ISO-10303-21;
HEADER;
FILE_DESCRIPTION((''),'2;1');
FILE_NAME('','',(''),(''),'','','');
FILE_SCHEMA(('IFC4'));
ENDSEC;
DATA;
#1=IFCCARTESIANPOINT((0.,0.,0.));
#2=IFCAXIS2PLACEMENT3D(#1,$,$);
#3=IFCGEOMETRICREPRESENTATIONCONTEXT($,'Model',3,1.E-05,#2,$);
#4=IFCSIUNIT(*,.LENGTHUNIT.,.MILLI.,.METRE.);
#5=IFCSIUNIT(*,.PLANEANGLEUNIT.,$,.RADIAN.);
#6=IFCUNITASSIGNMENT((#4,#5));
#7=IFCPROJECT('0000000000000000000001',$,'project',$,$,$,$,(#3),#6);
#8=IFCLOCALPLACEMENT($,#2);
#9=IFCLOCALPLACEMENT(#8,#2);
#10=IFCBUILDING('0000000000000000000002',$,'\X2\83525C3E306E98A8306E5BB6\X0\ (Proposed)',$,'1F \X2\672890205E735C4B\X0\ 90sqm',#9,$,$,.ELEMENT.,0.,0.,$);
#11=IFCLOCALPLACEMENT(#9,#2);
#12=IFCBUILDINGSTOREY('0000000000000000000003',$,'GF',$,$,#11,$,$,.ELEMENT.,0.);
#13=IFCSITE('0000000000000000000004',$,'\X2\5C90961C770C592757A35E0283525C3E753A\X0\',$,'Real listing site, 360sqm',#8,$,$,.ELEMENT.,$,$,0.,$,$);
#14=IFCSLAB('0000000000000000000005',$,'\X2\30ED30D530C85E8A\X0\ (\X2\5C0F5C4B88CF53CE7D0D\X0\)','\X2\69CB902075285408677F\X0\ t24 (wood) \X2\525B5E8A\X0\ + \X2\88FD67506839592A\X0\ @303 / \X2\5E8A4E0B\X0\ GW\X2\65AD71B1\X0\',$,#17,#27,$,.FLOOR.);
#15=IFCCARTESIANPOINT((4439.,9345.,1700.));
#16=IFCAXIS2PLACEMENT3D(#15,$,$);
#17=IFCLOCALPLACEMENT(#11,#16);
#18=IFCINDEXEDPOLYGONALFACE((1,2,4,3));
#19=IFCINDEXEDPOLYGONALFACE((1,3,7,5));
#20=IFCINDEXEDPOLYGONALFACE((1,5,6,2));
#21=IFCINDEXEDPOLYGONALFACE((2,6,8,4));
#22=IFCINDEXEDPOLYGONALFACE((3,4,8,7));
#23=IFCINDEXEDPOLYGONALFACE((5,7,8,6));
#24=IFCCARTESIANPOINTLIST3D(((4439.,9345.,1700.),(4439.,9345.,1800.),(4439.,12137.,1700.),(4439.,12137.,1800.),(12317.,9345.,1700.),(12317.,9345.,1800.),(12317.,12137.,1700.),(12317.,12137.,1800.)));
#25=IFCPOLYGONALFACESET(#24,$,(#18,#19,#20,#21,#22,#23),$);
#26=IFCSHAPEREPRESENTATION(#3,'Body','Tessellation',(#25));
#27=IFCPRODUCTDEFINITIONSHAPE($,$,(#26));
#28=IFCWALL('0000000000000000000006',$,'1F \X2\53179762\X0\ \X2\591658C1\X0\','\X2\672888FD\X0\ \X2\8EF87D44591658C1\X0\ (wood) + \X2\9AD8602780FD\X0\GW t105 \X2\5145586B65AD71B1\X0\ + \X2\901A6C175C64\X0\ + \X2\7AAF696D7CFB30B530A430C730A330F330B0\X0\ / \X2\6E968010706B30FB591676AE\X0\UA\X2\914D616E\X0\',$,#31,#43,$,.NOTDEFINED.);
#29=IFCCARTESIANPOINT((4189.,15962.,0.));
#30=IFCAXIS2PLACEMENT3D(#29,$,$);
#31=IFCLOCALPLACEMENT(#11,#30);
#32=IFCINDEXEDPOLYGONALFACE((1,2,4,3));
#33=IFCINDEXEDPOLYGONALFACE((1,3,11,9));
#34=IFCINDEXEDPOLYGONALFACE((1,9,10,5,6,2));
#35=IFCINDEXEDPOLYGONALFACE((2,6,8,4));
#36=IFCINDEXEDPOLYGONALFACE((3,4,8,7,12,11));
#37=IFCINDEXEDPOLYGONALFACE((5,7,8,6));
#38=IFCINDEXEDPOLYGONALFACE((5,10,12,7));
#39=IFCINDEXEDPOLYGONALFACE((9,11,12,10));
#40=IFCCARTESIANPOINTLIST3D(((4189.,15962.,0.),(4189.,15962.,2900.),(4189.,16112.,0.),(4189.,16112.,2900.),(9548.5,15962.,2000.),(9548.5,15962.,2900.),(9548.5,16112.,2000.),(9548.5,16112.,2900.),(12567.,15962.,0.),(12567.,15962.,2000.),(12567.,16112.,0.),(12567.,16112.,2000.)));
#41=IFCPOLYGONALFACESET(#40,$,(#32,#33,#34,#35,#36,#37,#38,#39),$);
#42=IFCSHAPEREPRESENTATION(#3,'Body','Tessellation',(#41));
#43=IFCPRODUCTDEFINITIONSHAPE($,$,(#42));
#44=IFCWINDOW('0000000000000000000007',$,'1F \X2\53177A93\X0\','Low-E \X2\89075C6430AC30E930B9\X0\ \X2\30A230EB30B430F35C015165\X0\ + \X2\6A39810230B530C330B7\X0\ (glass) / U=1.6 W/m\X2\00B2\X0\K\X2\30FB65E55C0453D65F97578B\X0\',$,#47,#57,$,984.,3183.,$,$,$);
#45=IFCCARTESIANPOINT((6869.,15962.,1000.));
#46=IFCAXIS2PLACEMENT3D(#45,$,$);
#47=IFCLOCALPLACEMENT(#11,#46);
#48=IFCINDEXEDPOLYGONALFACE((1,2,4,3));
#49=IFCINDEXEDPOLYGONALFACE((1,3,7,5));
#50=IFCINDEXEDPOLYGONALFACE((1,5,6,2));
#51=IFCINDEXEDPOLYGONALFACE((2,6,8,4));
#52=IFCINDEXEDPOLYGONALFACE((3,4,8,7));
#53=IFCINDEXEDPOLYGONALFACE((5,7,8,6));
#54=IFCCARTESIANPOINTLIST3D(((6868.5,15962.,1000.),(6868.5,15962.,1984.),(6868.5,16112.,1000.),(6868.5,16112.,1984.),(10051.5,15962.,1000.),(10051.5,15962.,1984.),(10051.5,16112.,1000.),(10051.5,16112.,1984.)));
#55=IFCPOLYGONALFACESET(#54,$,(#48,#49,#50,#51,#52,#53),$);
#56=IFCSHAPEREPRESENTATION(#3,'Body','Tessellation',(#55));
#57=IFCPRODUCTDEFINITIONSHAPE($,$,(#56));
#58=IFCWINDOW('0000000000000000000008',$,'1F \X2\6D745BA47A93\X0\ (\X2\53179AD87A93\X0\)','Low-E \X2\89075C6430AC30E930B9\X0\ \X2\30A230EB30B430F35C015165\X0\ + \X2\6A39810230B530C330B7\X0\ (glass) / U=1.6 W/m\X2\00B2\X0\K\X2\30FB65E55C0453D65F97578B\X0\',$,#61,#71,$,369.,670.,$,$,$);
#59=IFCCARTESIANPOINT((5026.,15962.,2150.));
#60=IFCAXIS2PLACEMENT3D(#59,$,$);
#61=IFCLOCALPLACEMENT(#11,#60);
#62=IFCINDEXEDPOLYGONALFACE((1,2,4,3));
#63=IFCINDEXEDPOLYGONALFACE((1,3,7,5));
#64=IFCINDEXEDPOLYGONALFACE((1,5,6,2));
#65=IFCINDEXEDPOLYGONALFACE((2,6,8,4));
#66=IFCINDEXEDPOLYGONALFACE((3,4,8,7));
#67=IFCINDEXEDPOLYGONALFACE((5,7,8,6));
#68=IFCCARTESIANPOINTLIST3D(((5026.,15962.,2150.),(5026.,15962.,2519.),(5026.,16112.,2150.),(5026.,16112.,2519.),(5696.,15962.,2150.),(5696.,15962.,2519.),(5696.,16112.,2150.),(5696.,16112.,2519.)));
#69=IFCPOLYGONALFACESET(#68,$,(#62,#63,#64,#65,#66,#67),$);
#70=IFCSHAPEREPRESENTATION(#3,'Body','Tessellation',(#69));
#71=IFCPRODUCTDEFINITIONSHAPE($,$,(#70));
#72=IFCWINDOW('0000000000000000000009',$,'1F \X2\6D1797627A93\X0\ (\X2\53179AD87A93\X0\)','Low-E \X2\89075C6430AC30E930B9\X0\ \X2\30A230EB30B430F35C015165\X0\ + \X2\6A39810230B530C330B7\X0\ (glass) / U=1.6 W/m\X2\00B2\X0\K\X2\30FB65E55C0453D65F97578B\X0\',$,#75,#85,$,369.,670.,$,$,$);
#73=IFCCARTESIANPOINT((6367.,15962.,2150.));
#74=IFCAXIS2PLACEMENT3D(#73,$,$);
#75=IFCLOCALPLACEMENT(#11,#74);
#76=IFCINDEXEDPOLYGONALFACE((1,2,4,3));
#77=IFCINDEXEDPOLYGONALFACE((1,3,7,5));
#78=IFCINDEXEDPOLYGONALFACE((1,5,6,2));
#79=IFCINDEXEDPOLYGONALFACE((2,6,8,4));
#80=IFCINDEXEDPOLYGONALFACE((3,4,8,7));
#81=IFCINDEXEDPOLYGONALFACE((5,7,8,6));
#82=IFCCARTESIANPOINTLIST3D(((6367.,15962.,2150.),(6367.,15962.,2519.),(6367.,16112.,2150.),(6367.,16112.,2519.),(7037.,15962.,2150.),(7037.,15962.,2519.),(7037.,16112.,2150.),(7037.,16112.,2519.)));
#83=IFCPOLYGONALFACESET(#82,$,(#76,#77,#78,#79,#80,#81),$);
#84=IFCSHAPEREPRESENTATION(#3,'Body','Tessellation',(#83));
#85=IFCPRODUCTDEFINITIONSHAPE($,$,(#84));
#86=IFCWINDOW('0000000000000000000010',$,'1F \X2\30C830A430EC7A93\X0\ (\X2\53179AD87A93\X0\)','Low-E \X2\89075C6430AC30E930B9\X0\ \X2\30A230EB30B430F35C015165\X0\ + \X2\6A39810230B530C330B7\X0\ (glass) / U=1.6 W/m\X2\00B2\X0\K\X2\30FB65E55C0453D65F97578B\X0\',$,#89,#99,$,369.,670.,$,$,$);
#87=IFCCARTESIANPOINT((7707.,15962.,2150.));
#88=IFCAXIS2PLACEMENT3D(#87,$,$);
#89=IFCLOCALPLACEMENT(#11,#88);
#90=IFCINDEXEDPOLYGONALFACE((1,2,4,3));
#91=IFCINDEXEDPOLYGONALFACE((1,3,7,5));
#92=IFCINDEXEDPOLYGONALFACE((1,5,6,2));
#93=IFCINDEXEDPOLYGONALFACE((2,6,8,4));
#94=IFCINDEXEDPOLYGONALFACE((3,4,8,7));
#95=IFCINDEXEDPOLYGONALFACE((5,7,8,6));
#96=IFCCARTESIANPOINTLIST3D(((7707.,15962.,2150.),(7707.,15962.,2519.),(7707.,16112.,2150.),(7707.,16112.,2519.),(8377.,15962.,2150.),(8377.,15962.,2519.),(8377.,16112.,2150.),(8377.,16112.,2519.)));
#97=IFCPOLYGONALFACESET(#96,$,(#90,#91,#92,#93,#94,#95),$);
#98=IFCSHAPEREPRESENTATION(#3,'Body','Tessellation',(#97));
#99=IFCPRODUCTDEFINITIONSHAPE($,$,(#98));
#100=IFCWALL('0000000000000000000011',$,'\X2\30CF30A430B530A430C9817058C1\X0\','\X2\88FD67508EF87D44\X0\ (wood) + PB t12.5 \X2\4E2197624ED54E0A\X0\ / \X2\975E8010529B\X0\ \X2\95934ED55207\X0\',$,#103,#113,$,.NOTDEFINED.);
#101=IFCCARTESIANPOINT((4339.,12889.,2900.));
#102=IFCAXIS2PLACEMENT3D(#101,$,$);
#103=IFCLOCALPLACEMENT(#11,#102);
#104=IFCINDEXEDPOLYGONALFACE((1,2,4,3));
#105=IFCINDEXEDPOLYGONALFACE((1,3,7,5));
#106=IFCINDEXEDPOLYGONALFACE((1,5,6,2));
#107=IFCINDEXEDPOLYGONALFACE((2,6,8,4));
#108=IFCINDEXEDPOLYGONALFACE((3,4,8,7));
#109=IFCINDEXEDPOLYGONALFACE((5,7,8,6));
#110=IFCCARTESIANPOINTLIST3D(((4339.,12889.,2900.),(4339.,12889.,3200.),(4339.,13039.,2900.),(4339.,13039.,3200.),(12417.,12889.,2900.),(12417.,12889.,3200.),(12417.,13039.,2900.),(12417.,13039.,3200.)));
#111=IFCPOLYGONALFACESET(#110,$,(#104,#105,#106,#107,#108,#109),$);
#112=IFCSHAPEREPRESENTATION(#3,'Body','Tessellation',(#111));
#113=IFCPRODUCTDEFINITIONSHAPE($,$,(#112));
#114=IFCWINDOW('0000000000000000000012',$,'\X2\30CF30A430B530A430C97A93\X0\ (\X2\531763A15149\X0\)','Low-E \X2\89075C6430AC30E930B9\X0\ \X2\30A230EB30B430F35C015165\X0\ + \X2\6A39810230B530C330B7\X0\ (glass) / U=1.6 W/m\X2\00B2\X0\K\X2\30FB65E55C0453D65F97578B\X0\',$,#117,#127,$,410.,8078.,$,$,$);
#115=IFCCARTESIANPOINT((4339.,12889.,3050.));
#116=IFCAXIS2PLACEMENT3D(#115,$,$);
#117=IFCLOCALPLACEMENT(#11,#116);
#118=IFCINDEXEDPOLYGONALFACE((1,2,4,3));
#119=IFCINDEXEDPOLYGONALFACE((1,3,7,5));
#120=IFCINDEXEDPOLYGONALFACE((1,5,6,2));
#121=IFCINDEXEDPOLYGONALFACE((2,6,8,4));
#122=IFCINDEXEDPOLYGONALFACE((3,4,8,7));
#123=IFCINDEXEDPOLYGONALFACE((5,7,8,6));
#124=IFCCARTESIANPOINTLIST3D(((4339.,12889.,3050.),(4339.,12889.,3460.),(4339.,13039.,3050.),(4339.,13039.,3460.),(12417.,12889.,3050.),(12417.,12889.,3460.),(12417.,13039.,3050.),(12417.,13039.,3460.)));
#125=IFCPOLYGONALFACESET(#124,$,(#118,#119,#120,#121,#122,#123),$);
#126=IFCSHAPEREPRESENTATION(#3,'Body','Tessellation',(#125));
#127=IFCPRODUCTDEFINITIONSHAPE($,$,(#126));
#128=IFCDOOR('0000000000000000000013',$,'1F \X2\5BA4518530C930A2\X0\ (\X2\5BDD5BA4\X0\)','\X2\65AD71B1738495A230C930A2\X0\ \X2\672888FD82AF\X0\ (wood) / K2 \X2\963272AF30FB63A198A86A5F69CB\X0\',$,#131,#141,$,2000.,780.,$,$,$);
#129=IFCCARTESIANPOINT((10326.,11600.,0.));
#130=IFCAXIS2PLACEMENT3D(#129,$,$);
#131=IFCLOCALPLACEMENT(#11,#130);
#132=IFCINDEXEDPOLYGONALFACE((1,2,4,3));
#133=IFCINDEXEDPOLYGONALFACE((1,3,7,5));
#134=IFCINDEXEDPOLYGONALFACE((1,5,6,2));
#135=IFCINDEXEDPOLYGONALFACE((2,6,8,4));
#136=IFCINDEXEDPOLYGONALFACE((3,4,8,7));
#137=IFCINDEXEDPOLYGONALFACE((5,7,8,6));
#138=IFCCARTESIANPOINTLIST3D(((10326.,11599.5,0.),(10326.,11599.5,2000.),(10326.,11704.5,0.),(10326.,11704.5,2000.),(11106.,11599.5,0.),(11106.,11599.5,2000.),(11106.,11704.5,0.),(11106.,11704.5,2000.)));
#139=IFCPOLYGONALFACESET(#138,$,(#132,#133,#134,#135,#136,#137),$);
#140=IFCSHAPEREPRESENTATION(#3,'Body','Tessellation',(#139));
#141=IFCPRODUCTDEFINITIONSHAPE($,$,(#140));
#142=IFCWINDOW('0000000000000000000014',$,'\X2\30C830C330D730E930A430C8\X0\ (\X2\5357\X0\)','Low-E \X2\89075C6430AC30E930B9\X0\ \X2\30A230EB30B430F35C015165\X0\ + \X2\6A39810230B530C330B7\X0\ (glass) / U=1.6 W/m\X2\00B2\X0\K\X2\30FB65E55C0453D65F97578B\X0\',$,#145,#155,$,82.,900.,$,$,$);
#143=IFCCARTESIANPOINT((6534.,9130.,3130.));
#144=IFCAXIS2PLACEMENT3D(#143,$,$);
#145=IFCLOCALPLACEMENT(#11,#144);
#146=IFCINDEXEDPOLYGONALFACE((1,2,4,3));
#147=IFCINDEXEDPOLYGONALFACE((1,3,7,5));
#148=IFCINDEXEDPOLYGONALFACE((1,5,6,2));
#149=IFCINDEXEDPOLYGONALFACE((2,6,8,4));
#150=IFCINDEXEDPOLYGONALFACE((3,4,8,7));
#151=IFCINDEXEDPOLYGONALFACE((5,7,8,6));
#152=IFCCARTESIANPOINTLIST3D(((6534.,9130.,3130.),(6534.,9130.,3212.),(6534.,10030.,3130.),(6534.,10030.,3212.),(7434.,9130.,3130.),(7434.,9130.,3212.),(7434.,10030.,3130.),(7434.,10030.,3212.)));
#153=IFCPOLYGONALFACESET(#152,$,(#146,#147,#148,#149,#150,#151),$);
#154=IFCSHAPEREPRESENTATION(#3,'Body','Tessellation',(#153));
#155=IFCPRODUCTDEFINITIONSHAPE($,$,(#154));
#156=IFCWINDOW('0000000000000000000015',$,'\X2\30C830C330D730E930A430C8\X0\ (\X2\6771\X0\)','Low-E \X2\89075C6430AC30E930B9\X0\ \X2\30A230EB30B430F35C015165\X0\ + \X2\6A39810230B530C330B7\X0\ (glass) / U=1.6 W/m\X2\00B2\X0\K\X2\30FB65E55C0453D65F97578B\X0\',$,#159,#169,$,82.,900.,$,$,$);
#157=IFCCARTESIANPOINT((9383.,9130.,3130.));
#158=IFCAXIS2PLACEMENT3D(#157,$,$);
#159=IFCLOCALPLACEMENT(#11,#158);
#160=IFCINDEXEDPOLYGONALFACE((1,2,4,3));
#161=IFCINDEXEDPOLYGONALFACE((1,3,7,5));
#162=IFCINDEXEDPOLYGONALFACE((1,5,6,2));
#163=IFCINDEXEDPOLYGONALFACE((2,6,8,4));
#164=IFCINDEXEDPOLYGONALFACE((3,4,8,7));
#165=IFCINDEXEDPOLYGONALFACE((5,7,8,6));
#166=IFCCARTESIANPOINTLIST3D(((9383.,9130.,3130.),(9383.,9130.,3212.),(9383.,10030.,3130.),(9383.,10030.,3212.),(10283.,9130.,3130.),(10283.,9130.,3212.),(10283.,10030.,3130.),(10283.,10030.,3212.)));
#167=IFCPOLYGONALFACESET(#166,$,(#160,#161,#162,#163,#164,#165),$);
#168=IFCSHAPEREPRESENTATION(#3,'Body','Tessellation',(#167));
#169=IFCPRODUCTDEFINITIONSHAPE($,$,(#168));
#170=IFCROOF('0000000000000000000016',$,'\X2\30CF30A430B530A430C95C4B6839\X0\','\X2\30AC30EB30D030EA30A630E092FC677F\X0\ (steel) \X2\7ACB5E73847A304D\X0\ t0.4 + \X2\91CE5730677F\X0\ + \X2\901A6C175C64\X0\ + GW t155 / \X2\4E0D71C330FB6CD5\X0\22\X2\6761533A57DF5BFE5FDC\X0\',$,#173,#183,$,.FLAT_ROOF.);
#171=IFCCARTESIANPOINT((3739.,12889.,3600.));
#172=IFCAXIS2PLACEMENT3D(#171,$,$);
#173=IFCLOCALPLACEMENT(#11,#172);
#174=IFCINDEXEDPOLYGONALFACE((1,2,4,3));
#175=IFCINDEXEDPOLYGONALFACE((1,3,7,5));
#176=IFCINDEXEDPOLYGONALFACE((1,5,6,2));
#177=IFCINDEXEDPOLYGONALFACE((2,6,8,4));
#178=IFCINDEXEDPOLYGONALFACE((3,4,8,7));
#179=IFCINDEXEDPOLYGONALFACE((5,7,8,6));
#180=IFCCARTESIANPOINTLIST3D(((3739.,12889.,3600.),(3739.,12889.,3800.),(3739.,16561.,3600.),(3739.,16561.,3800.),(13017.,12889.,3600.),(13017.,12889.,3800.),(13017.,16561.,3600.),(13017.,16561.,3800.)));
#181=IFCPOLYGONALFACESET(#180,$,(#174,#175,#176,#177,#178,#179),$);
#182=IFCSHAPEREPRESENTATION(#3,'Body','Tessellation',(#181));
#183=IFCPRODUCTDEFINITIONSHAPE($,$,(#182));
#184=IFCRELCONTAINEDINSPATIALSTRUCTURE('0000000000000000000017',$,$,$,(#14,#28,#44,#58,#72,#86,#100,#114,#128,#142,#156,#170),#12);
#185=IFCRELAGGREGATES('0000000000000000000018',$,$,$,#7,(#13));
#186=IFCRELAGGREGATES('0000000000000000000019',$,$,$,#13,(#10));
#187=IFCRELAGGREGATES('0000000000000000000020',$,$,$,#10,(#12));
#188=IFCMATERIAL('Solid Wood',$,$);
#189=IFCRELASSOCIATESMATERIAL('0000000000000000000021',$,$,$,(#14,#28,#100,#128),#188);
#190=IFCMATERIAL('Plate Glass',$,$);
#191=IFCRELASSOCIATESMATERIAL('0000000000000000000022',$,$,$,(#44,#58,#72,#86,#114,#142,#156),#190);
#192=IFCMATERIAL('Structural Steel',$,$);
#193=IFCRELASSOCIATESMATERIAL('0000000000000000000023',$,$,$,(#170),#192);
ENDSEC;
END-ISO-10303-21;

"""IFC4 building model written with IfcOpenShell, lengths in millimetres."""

from ifc_helpers import new_model, si_unit, frame, frame_2d, origin, place, context, project, spatial, rectangle, extrude, material, element, fill, save


model = new_model("IFC4")

# Units and contexts
model_context = context("Model", 3, precision=1e-05, world=origin())
ifc_project = project(units=[si_unit("LENGTHUNIT", "METRE", prefix="MILLI"), si_unit("PLANEANGLEUNIT", "RADIAN")], contexts=[model_context])

# Site, building, storey
site_placement = place(None, origin())
site = spatial("IfcSite", under=ifc_project, at=site_placement, Name="岐阜県大垣市荒尾町", ObjectType="Real listing site, 360sqm", CompositionType="ELEMENT", RefElevation=0.0)
building_placement = place(site_placement, origin())
building = spatial("IfcBuilding", under=site, at=building_placement, Name="荒尾の風の家 (Proposed)", ObjectType="1F 木造平屋 90sqm", CompositionType="ELEMENT", ElevationOfRefHeight=0.0, ElevationOfTerrain=0.0)
storey_placement = place(building_placement, origin())
storey = spatial("IfcBuildingStorey", under=building, at=storey_placement, Name="GF", CompositionType="ELEMENT", Elevation=0.0)

# Slab
ifc_material_1 = material(Name="Solid Wood")
slab_placement = place(storey_placement, frame((4439.0, 9345.0, 1700.0)))
element("IfcSlab", 1, at=slab_placement, inside=storey, material=ifc_material_1, Name="ロフト床 (小屋裏収納)", Description="構造用合板 t24 (wood) 剛床 + 製材根太 @303 / 床下 GW断熱", PredefinedType="FLOOR", context=model_context, shape_type="SweptSolid", body=[
    extrude(rectangle(XDim=7878.0, YDim=2792.0, at=frame_2d((3939.0, 1396.0))), frame((4439.0, 9345.0, 1700.0)), (0.0, 0.0, 1.0), 100.0),
])

# Wall, openings, windows
wall_1_placement = place(storey_placement, frame((4189.0, 15962.0, 0.0)))
wall_1 = element("IfcWall", 2, at=wall_1_placement, inside=storey, material=ifc_material_1, Name="1F 北面 外壁", Description="木製 軸組外壁 (wood) + 高性能GW t105 充填断熱 + 通気層 + 窯業系サイディング / 準耐火・外皮UA配慮", PredefinedType="NOTDEFINED", context=model_context, shape_type="SweptSolid", body=[
    extrude(rectangle(XDim=8378.0, YDim=150.0, at=frame_2d((4189.0, 75.0))), frame((4189.0, 15962.0, 0.0)), (0.0, 0.0, 1.0), 2900.0),
])
opening_1_placement = place(storey_placement, frame((6869.0, 15962.0, 1000.0)))
opening_1 = element("IfcOpeningElement", 3, at=opening_1_placement, cuts=wall_1, PredefinedType="NOTDEFINED", context=model_context, shape_type="SweptSolid", body=[
    extrude(rectangle(XDim=3183.0, YDim=150.0, at=frame_2d((1591.0, 75.0))), frame((6869.0, 15962.0, 1000.0)), (0.0, 0.0, 1.0), 984.0),
])
opening_2_placement = place(storey_placement, frame((5026.0, 15962.0, 2150.0)))
opening_2 = element("IfcOpeningElement", 4, at=opening_2_placement, cuts=wall_1, PredefinedType="NOTDEFINED", context=model_context, shape_type="SweptSolid", body=[
    extrude(rectangle(XDim=670.0, YDim=150.0, at=frame_2d((335.0, 75.0))), frame((5026.0, 15962.0, 2150.0)), (0.0, 0.0, 1.0), 369.0),
])
opening_3_placement = place(storey_placement, frame((6367.0, 15962.0, 2150.0)))
opening_3 = element("IfcOpeningElement", 5, at=opening_3_placement, cuts=wall_1, PredefinedType="NOTDEFINED", context=model_context, shape_type="SweptSolid", body=[
    extrude(rectangle(XDim=670.0, YDim=150.0, at=frame_2d((335.0, 75.0))), frame((6367.0, 15962.0, 2150.0)), (0.0, 0.0, 1.0), 369.0),
])
opening_4_placement = place(storey_placement, frame((7707.0, 15962.0, 2150.0)))
opening_4 = element("IfcOpeningElement", 6, at=opening_4_placement, cuts=wall_1, PredefinedType="NOTDEFINED", context=model_context, shape_type="SweptSolid", body=[
    extrude(rectangle(XDim=670.0, YDim=150.0, at=frame_2d((335.0, 75.0))), frame((7707.0, 15962.0, 2150.0)), (0.0, 0.0, 1.0), 369.0),
])
ifc_material_2 = material(Name="Plate Glass")
window_1_placement = place(storey_placement, frame((6869.0, 15962.0, 1000.0)))
window_1 = element("IfcWindow", 7, at=window_1_placement, inside=storey, material=ifc_material_2, Name="1F 北窓", Description="Low-E 複層ガラス アルゴン封入 + 樹脂サッシ (glass) / U=1.6 W/m²K・日射取得型", OverallHeight=984.0, OverallWidth=3183.0, context=model_context, shape_type="SweptSolid", body=[
    extrude(rectangle(XDim=3183.0, YDim=150.0, at=frame_2d((1591.0, 75.0))), frame((6869.0, 15962.0, 1000.0)), (0.0, 0.0, 1.0), 984.0),
])
fill(opening_1, window_1)
window_2_placement = place(storey_placement, frame((5026.0, 15962.0, 2150.0)))
window_2 = element("IfcWindow", 8, at=window_2_placement, inside=storey, material=ifc_material_2, Name="1F 浴室窓 (北高窓)", Description="Low-E 複層ガラス アルゴン封入 + 樹脂サッシ (glass) / U=1.6 W/m²K・日射取得型", OverallHeight=369.0, OverallWidth=670.0, context=model_context, shape_type="SweptSolid", body=[
    extrude(rectangle(XDim=670.0, YDim=150.0, at=frame_2d((335.0, 75.0))), frame((5026.0, 15962.0, 2150.0)), (0.0, 0.0, 1.0), 369.0),
])
fill(opening_2, window_2)
window_3_placement = place(storey_placement, frame((6367.0, 15962.0, 2150.0)))
window_3 = element("IfcWindow", 9, at=window_3_placement, inside=storey, material=ifc_material_2, Name="1F 洗面窓 (北高窓)", Description="Low-E 複層ガラス アルゴン封入 + 樹脂サッシ (glass) / U=1.6 W/m²K・日射取得型", OverallHeight=369.0, OverallWidth=670.0, context=model_context, shape_type="SweptSolid", body=[
    extrude(rectangle(XDim=670.0, YDim=150.0, at=frame_2d((335.0, 75.0))), frame((6367.0, 15962.0, 2150.0)), (0.0, 0.0, 1.0), 369.0),
])
fill(opening_3, window_3)
window_4_placement = place(storey_placement, frame((7707.0, 15962.0, 2150.0)))
window_4 = element("IfcWindow", 10, at=window_4_placement, inside=storey, material=ifc_material_2, Name="1F トイレ窓 (北高窓)", Description="Low-E 複層ガラス アルゴン封入 + 樹脂サッシ (glass) / U=1.6 W/m²K・日射取得型", OverallHeight=369.0, OverallWidth=670.0, context=model_context, shape_type="SweptSolid", body=[
    extrude(rectangle(XDim=670.0, YDim=150.0, at=frame_2d((335.0, 75.0))), frame((7707.0, 15962.0, 2150.0)), (0.0, 0.0, 1.0), 369.0),
])
fill(opening_4, window_4)

# Wall, opening, window
wall_2_placement = place(storey_placement, frame((4339.0, 12889.0, 2900.0)))
wall_2 = element("IfcWall", 11, at=wall_2_placement, inside=storey, material=ifc_material_1, Name="ハイサイド腰壁", Description="製材軸組 (wood) + PB t12.5 両面仕上 / 非耐力 間仕切", PredefinedType="NOTDEFINED", context=model_context, shape_type="SweptSolid", body=[
    extrude(rectangle(XDim=8078.0, YDim=150.0, at=frame_2d((4039.0, 75.0))), frame((4339.0, 12889.0, 2900.0)), (0.0, 0.0, 1.0), 700.0),
])
opening_5_placement = place(storey_placement, frame((4339.0, 12889.0, 3050.0)))
opening_5 = element("IfcOpeningElement", 12, at=opening_5_placement, cuts=wall_2, PredefinedType="NOTDEFINED", context=model_context, shape_type="SweptSolid", body=[
    extrude(rectangle(XDim=8078.0, YDim=150.0, at=frame_2d((4039.0, 75.0))), frame((4339.0, 12889.0, 3050.0)), (0.0, 0.0, 1.0), 410.0),
])
window_5_placement = place(storey_placement, frame((4339.0, 12889.0, 3050.0)))
window_5 = element("IfcWindow", 13, at=window_5_placement, inside=storey, material=ifc_material_2, Name="ハイサイド窓 (北採光)", Description="Low-E 複層ガラス アルゴン封入 + 樹脂サッシ (glass) / U=1.6 W/m²K・日射取得型", OverallHeight=410.0, OverallWidth=8078.0, context=model_context, shape_type="SweptSolid", body=[
    extrude(rectangle(XDim=8078.0, YDim=150.0, at=frame_2d((4039.0, 75.0))), frame((4339.0, 12889.0, 3050.0)), (0.0, 0.0, 1.0), 410.0),
])
fill(opening_5, window_5)

# Door
door_1_placement = place(storey_placement, frame((10326.0, 11600.0, 0.0)))
element("IfcDoor", 14, at=door_1_placement, inside=storey, material=ifc_material_1, Name="1F 室内ドア (寝室)", Description="断熱玄関ドア 木製芯 (wood) / K2 防犯・採風機構", OverallHeight=2000.0, OverallWidth=780.0, context=model_context, shape_type="SweptSolid", body=[
    extrude(rectangle(XDim=780.0, YDim=105.0, at=frame_2d((390.0, 52.0))), frame((10326.0, 11600.0, 0.0)), (0.0, 0.0, 1.0), 2000.0),
])

# Windows
window_6_placement = place(storey_placement, frame((6534.0, 9130.0, 3130.0)))
element("IfcWindow", 15, at=window_6_placement, inside=storey, material=ifc_material_2, Name="トップライト (南)", Description="Low-E 複層ガラス アルゴン封入 + 樹脂サッシ (glass) / U=1.6 W/m²K・日射取得型", OverallHeight=82.0, OverallWidth=900.0, context=model_context, shape_type="SweptSolid", body=[
    extrude(rectangle(XDim=900.0, YDim=900.0, at=frame_2d((450.0, 450.0))), frame((6534.0, 9130.0, 3130.0)), (0.0, 0.0, 1.0), 82.0),
])
window_7_placement = place(storey_placement, frame((9383.0, 9130.0, 3130.0)))
element("IfcWindow", 16, at=window_7_placement, inside=storey, material=ifc_material_2, Name="トップライト (東)", Description="Low-E 複層ガラス アルゴン封入 + 樹脂サッシ (glass) / U=1.6 W/m²K・日射取得型", OverallHeight=82.0, OverallWidth=900.0, context=model_context, shape_type="SweptSolid", body=[
    extrude(rectangle(XDim=900.0, YDim=900.0, at=frame_2d((450.0, 450.0))), frame((9383.0, 9130.0, 3130.0)), (0.0, 0.0, 1.0), 82.0),
])

# Roof
ifc_material_3 = material(Name="Structural Steel")
roof_placement = place(storey_placement, frame((3739.0, 12889.0, 3600.0)))
element("IfcRoof", 17, at=roof_placement, inside=storey, material=ifc_material_3, Name="ハイサイド屋根", Description="ガルバリウム鋼板 (steel) 立平葺き t0.4 + 野地板 + 通気層 + GW t155 / 不燃・法22条区域対応", PredefinedType="FLAT_ROOF", context=model_context, shape_type="SweptSolid", body=[
    extrude(rectangle(XDim=9278.0, YDim=3672.0, at=frame_2d((4639.0, 1836.0))), frame((3739.0, 12889.0, 3600.0)), (0.0, 0.0, 1.0), 200.0),
])

save(model, "model.ifc")
